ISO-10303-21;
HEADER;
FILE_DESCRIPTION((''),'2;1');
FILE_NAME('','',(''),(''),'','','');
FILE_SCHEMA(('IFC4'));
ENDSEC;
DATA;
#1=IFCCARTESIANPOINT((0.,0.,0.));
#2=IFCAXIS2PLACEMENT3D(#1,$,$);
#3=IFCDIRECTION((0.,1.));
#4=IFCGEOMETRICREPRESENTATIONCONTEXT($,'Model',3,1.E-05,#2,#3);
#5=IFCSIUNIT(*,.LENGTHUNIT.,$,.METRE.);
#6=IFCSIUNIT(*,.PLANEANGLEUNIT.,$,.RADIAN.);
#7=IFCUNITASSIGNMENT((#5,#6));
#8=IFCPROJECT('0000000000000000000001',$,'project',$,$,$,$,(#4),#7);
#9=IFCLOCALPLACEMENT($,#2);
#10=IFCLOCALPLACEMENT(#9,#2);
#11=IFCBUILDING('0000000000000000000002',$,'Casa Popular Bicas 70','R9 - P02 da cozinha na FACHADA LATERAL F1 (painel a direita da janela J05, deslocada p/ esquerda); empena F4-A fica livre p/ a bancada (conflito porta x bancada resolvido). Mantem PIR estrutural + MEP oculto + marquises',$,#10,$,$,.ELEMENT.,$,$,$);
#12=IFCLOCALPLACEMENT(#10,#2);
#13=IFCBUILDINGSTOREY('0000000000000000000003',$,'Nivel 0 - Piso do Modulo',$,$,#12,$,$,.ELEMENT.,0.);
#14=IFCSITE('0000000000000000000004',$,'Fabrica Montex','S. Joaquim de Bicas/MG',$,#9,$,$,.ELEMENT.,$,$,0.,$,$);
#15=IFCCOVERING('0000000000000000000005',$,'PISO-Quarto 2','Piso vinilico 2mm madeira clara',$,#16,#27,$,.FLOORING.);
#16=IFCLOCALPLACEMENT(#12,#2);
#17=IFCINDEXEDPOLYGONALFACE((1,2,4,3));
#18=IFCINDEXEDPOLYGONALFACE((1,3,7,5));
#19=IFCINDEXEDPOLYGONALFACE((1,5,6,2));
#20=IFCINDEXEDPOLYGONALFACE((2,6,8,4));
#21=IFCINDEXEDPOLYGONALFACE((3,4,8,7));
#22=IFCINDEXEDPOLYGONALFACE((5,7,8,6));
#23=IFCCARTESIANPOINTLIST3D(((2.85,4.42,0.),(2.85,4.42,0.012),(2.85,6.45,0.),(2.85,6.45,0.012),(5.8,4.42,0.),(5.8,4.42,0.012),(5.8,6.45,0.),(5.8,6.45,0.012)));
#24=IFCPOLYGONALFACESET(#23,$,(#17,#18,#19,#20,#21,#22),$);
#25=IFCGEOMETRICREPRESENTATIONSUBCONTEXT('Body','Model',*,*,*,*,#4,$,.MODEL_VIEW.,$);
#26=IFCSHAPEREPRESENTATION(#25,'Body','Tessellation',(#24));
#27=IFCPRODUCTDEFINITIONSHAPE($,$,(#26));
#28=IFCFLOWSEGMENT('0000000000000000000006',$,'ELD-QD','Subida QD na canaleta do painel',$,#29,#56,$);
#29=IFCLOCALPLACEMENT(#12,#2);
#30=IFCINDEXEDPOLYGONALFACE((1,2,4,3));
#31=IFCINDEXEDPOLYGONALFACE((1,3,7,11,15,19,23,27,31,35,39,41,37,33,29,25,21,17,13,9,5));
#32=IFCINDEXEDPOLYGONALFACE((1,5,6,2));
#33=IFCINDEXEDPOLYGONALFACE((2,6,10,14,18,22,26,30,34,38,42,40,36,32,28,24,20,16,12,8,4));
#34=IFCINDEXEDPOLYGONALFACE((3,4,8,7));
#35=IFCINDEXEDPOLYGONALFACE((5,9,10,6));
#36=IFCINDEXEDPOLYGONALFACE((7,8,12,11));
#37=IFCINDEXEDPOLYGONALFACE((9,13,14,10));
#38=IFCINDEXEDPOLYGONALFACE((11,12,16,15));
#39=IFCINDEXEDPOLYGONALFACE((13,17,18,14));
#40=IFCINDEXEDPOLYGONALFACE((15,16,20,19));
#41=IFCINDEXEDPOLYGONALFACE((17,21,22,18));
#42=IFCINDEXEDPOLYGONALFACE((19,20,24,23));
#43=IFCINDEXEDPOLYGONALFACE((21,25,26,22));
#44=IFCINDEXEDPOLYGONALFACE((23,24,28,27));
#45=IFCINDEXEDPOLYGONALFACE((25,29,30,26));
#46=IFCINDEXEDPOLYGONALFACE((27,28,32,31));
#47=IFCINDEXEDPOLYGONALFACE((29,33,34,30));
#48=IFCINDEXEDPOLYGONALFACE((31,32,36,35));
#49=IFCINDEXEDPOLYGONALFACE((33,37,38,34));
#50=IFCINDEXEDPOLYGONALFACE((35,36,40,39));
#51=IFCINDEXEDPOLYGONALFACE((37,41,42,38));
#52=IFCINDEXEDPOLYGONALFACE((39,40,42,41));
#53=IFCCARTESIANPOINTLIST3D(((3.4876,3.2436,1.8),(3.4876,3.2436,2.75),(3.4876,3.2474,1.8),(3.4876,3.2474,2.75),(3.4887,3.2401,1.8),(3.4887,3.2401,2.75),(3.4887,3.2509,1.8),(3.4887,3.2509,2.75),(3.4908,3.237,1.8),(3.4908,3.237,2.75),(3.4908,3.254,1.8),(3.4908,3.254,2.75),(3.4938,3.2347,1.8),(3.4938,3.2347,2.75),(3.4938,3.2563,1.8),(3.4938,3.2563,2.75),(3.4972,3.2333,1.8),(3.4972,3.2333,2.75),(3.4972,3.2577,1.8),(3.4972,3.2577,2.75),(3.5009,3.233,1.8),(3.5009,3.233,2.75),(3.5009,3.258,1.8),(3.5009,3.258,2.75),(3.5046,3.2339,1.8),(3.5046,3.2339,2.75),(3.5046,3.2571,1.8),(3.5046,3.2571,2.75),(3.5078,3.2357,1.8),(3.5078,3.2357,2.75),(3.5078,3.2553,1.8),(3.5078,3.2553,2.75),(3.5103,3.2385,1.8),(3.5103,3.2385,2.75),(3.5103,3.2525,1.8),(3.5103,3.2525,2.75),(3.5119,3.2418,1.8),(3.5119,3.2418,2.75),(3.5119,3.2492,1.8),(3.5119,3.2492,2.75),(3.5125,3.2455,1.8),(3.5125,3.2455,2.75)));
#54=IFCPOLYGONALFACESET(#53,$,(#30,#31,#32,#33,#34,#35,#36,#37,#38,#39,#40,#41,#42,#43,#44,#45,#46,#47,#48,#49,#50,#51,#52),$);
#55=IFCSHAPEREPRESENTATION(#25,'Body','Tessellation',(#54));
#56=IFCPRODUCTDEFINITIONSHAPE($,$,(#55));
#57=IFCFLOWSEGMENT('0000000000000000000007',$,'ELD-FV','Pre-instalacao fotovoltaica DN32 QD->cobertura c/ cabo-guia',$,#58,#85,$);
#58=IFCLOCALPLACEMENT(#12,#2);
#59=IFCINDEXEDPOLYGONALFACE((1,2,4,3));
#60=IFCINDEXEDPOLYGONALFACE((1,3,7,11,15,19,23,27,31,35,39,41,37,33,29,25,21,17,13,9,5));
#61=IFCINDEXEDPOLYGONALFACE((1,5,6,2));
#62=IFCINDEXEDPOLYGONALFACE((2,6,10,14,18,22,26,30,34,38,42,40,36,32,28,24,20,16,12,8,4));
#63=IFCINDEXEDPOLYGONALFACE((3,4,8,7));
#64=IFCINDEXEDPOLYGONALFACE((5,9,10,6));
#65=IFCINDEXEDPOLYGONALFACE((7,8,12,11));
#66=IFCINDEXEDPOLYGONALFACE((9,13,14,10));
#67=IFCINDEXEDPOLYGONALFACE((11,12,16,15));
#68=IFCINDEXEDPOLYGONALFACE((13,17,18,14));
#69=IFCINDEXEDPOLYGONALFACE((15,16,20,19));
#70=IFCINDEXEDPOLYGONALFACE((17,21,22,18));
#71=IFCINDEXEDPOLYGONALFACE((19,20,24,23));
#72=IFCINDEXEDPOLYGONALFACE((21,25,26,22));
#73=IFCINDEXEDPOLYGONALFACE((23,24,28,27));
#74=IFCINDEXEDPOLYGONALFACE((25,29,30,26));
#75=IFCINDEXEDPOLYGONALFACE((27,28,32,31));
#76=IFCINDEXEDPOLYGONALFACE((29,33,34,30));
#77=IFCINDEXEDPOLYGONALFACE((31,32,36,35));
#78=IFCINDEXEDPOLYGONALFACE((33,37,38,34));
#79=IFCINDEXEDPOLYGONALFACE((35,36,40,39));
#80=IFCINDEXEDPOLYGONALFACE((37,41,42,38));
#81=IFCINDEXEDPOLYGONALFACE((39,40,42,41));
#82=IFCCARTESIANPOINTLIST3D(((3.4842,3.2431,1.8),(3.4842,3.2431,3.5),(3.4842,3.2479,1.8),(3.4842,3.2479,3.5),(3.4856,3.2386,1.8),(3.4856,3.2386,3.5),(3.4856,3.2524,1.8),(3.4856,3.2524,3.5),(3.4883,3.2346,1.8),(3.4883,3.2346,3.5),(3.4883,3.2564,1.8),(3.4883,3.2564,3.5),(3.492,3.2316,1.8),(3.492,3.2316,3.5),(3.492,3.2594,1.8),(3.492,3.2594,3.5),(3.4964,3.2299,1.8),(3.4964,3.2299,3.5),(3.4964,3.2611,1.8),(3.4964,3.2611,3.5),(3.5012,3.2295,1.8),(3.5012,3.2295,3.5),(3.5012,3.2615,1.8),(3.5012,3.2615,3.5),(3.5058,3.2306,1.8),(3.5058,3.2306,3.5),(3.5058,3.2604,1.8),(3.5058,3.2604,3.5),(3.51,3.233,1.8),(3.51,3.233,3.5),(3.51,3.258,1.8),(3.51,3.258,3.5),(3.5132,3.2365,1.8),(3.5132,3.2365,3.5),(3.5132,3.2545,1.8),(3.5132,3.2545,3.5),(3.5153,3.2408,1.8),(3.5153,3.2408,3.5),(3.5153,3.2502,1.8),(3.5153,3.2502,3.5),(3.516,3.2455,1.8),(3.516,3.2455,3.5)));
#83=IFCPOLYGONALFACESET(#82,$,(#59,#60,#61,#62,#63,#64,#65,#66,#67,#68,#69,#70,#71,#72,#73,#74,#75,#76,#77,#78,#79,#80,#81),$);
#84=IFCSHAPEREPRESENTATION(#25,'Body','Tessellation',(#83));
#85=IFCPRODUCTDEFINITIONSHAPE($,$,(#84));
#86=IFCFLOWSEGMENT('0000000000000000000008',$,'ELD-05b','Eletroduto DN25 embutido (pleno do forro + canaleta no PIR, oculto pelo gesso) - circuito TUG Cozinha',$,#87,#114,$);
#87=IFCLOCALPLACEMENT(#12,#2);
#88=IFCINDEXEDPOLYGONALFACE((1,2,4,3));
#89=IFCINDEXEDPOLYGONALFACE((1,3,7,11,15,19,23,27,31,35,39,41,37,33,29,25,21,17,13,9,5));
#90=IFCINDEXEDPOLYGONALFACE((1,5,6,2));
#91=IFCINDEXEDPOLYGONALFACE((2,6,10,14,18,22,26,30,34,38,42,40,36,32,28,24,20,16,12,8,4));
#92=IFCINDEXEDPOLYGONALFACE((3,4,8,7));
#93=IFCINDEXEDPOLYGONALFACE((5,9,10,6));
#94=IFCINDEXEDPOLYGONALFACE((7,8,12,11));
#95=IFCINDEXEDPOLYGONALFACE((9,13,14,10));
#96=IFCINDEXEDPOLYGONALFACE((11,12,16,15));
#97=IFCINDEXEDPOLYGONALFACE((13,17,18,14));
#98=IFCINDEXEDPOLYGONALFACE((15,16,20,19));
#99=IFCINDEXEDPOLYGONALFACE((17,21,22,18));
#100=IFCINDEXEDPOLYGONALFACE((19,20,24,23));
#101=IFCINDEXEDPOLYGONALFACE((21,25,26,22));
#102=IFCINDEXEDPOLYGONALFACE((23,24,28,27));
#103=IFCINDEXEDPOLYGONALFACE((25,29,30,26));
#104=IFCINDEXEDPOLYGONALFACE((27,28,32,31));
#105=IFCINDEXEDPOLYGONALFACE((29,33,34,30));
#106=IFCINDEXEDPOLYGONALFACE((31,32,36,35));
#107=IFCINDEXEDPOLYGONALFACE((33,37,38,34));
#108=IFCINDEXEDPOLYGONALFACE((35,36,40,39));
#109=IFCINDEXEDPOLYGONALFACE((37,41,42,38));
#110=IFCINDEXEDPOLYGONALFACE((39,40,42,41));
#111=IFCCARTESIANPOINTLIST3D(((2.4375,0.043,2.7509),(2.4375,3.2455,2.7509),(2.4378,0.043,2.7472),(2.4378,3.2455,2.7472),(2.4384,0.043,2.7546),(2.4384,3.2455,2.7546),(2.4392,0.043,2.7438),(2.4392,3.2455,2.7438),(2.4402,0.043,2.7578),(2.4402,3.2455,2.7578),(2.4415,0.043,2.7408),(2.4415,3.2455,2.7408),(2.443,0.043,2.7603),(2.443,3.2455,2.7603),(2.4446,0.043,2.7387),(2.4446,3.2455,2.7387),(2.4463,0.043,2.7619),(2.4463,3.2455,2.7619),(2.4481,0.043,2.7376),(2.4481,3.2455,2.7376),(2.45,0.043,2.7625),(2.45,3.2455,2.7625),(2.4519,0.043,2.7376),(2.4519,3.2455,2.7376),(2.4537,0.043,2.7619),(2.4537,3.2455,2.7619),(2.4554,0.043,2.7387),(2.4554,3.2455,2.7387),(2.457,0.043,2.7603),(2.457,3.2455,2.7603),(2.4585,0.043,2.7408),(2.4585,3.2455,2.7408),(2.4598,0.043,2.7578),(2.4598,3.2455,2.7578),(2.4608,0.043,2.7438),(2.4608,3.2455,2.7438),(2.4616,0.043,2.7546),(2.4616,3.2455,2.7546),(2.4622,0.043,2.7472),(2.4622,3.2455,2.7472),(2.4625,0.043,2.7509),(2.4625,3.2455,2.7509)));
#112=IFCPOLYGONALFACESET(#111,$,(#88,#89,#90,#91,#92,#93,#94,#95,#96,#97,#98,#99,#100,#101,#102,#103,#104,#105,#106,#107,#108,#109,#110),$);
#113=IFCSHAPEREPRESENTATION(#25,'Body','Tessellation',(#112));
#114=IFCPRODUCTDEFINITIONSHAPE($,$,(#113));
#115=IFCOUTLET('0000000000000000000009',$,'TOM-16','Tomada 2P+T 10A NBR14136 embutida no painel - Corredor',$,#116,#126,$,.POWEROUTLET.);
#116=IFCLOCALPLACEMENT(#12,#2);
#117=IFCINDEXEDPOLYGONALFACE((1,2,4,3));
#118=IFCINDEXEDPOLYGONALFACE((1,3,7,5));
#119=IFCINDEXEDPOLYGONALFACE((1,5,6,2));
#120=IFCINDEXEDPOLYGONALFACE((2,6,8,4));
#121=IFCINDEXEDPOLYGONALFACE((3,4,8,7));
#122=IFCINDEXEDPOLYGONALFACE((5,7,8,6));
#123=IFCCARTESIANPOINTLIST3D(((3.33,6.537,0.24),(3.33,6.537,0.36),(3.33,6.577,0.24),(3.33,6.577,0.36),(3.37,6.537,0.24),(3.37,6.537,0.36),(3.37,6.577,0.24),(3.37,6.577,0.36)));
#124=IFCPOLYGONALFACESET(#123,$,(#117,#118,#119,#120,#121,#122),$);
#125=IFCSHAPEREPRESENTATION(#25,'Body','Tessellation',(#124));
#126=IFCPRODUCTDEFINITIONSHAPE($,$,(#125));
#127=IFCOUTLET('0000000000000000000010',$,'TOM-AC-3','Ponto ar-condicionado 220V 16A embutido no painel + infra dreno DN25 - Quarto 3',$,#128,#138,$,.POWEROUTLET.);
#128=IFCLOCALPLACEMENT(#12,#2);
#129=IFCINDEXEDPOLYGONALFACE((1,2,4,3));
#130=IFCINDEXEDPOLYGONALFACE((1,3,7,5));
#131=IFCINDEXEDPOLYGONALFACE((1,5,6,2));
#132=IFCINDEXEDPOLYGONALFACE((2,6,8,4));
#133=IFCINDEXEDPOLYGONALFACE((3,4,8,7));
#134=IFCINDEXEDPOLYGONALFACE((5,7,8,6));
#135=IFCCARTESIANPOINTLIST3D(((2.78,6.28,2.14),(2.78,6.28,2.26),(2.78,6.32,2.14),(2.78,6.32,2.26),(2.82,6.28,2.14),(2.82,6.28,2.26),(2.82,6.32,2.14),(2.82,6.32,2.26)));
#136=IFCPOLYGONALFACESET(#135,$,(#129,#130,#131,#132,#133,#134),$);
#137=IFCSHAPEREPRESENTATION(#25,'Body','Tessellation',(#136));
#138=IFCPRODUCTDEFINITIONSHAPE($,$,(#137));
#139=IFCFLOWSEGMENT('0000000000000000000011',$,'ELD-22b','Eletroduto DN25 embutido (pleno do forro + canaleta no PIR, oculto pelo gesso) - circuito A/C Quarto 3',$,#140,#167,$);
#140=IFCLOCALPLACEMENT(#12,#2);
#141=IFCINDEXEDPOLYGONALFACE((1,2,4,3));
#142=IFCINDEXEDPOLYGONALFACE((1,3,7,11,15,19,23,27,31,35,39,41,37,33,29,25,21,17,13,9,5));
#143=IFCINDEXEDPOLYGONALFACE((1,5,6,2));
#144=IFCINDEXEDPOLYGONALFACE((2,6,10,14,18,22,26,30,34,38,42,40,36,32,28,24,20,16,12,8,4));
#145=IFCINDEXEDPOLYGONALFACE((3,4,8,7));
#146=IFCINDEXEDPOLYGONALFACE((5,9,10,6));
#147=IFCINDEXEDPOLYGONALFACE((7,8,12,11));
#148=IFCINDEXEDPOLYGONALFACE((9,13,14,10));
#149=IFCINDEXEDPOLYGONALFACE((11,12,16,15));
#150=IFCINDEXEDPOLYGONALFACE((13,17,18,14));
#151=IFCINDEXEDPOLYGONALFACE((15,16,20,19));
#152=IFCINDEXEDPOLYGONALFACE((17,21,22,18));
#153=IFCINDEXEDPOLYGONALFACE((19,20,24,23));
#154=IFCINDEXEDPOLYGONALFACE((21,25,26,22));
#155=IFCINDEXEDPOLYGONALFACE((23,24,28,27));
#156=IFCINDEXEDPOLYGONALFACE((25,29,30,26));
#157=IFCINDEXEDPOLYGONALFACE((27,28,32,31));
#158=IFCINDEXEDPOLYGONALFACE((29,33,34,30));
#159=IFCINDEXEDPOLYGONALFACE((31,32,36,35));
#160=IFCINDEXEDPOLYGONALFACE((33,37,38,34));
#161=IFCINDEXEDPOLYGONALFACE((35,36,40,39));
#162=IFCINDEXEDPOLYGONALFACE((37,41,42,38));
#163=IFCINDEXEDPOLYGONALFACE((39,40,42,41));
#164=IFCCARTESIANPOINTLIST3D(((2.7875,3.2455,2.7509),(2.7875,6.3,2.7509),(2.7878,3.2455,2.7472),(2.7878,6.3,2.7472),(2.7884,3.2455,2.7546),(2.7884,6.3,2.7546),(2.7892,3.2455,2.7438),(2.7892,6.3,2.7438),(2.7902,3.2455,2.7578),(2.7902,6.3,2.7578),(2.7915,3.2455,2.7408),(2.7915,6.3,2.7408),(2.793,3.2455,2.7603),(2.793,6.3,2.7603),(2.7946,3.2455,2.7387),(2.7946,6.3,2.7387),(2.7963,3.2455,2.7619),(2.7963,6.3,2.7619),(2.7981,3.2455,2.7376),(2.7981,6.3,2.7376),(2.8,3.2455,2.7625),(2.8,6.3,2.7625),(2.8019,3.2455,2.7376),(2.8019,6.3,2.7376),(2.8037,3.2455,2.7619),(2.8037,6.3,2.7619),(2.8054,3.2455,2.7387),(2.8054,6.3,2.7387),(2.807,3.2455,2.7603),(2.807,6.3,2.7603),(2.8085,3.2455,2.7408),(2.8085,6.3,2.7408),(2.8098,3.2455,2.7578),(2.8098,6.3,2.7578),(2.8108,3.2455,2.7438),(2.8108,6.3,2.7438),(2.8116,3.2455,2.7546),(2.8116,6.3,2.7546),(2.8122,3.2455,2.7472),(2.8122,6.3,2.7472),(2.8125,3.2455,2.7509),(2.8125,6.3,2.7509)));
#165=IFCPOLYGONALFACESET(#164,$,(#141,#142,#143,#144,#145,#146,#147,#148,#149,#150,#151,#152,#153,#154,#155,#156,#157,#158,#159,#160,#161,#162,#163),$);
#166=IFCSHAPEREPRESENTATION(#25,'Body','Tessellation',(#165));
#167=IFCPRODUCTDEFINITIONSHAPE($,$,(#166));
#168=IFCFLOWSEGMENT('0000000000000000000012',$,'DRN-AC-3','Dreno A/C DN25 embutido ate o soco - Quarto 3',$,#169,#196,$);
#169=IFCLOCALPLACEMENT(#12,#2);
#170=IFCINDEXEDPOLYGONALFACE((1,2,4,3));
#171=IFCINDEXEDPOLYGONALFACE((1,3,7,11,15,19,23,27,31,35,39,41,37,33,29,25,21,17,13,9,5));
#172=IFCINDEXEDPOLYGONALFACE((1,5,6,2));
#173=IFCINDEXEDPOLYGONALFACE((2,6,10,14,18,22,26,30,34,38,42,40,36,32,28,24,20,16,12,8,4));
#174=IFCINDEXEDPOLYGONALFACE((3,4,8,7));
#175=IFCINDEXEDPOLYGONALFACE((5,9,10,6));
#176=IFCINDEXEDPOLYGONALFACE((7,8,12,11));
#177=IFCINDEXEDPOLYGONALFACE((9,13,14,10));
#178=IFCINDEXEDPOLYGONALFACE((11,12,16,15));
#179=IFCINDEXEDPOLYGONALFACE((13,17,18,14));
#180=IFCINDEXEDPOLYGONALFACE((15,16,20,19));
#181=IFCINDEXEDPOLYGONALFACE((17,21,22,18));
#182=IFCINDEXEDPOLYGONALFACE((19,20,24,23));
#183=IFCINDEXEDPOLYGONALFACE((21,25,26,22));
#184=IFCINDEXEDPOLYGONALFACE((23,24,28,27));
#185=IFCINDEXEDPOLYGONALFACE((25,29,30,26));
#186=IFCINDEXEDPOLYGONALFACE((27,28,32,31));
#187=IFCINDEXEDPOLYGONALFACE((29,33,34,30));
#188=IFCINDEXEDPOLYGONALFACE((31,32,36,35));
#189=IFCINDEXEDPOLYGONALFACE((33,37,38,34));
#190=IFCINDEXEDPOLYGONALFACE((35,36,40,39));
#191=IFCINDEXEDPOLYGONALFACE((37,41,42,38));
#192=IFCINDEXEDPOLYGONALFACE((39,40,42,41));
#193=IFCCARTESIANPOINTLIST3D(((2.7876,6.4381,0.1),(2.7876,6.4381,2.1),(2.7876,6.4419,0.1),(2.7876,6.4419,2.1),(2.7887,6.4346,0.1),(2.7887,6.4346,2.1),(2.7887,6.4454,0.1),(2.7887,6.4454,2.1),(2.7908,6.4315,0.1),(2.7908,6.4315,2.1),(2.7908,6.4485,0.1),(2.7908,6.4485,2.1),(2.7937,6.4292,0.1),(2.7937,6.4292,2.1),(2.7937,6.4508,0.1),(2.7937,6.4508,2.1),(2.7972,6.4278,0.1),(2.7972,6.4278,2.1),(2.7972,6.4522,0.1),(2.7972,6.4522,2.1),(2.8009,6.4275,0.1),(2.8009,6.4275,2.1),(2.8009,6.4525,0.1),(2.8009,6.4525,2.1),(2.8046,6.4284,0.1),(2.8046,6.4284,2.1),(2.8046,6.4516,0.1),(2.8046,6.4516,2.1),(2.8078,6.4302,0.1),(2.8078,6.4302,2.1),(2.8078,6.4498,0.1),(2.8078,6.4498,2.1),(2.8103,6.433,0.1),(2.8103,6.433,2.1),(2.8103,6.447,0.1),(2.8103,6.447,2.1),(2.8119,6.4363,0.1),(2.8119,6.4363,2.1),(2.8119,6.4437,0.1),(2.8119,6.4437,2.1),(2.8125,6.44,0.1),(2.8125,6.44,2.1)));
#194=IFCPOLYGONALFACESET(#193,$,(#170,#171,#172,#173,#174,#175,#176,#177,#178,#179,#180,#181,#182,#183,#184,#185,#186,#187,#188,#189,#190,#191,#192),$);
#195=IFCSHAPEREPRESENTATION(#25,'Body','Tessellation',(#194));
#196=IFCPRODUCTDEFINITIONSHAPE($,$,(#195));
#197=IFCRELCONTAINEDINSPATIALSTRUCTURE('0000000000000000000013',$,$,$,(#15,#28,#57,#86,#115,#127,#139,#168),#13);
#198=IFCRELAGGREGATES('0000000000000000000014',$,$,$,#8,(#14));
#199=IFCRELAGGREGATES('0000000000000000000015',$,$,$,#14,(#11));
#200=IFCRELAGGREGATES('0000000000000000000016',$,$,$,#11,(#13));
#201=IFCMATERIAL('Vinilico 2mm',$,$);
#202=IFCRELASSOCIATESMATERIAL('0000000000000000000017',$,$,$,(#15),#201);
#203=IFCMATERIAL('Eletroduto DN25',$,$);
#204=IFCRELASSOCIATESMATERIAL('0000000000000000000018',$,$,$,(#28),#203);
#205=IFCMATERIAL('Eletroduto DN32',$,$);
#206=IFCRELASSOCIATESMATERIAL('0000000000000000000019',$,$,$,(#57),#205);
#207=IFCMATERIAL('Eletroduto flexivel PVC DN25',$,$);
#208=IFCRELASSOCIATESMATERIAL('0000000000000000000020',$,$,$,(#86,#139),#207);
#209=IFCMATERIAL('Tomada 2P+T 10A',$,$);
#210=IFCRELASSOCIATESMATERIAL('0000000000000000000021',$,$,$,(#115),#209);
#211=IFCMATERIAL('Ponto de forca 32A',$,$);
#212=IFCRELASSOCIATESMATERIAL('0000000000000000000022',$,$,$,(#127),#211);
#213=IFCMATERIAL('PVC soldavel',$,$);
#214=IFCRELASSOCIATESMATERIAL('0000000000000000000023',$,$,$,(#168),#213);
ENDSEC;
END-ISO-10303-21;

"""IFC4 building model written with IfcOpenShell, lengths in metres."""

from ifc_helpers import new_model, si_unit, direction, frame, frame_2d, origin, origin_2d, place, context, subcontext, project, spatial, rectangle, circle, extrude, material, element, save


model = new_model("IFC4")

# Units and contexts
model_context = context("Model", 3, precision=1e-05, world=origin(), true_north=direction((0.0, 1.0)))
body_context = subcontext(model_context, "Body", "Model", "MODEL_VIEW")
ifc_project = project(units=[si_unit("LENGTHUNIT", "METRE"), si_unit("PLANEANGLEUNIT", "RADIAN")], contexts=[model_context])

# Site, building, storey
site_placement = place(None, origin())
site = spatial("IfcSite", under=ifc_project, at=site_placement, Name="Fabrica Montex", Description="S. Joaquim de Bicas/MG", CompositionType="ELEMENT", RefElevation=0.0)
building_placement = place(site_placement, origin())
building = spatial("IfcBuilding", under=site, at=building_placement, Name="Casa Popular Bicas 70", Description="R9 - P02 da cozinha na FACHADA LATERAL F1 (painel a direita da janela J05, deslocada p/ esquerda); empena F4-A fica livre p/ a bancada (conflito porta x bancada resolvido). Mantem PIR estrutural + MEP oculto + marquises", CompositionType="ELEMENT")
storey_placement = place(building_placement, origin())
storey = spatial("IfcBuildingStorey", under=building, at=storey_placement, Name="Nivel 0 - Piso do Modulo", CompositionType="ELEMENT", Elevation=0.0)

# Covering
ifc_material_1 = material(Name="Vinilico 2mm")
covering_1_placement = place(storey_placement, frame((2.85, 4.42, 0.0)))
element("IfcCovering", 1, at=covering_1_placement, inside=storey, material=ifc_material_1, Name="PISO-Quarto 2", Description="Piso vinilico 2mm madeira clara", PredefinedType="FLOORING", context=body_context, shape_type="SweptSolid", body=[
    extrude(rectangle(XDim=2.95, YDim=2.03, at=frame_2d((1.475, 1.015))), origin(), (0.0, 0.0, 1.0), 0.012),
])

# Flow segments
ifc_material_2 = material(Name="Eletroduto DN25")
flow_segment_1_placement = place(storey_placement, frame((3.5, 3.2455, 1.8), z_axis=(0.0, 0.0, 1.0), x_axis=(1.0, 0.0, 0.0)))
element("IfcFlowSegment", 2, at=flow_segment_1_placement, inside=storey, material=ifc_material_2, Name="ELD-QD", Description="Subida QD na canaleta do painel", context=body_context, shape_type="SweptSolid", body=[
    extrude(circle(Radius=0.0125, at=origin_2d()), origin(), (0.0, 0.0, 1.0), 0.95),
])
ifc_material_3 = material(Name="Eletroduto DN32")
flow_segment_2_placement = place(storey_placement, frame((3.5, 3.2455, 1.8), z_axis=(0.0, 0.0, 1.0), x_axis=(1.0, 0.0, 0.0)))
element("IfcFlowSegment", 3, at=flow_segment_2_placement, inside=storey, material=ifc_material_3, Name="ELD-FV", Description="Pre-instalacao fotovoltaica DN32 QD->cobertura c/ cabo-guia", context=body_context, shape_type="SweptSolid", body=[
    extrude(circle(Radius=0.016, at=origin_2d()), origin(), (0.0, 0.0, 1.0), 1.7),
])
ifc_material_4 = material(Name="Eletroduto flexivel PVC DN25")
flow_segment_3_placement = place(storey_placement, frame((2.45, 3.2455, 2.75), z_axis=(0.0, -1.0, 0.0), x_axis=(0.0, 0.0, 1.0)))
element("IfcFlowSegment", 4, at=flow_segment_3_placement, inside=storey, material=ifc_material_4, Name="ELD-05b", Description="Eletroduto DN25 embutido (pleno do forro + canaleta no PIR, oculto pelo gesso) - circuito TUG Cozinha", context=body_context, shape_type="SweptSolid", body=[
    extrude(circle(Radius=0.0125, at=origin_2d()), origin(), (0.0, 0.0, 1.0), 3.2025),
])

# Outlets
ifc_material_5 = material(Name="Tomada 2P+T 10A")
outlet_1_placement = place(storey_placement, frame((3.33, 6.537, 0.24)))
element("IfcOutlet", 5, at=outlet_1_placement, inside=storey, material=ifc_material_5, Name="TOM-16", Description="Tomada 2P+T 10A NBR14136 embutida no painel - Corredor", PredefinedType="POWEROUTLET", context=body_context, shape_type="SweptSolid", body=[
    extrude(rectangle(XDim=0.04, YDim=0.04, at=frame_2d((0.02, 0.02))), origin(), (0.0, 0.0, 1.0), 0.12),
])
ifc_material_6 = material(Name="Ponto de forca 32A")
outlet_2_placement = place(storey_placement, frame((2.78, 6.28, 2.14)))
element("IfcOutlet", 6, at=outlet_2_placement, inside=storey, material=ifc_material_6, Name="TOM-AC-3", Description="Ponto ar-condicionado 220V 16A embutido no painel + infra dreno DN25 - Quarto 3", PredefinedType="POWEROUTLET", context=body_context, shape_type="SweptSolid", body=[
    extrude(rectangle(XDim=0.04, YDim=0.04, at=frame_2d((0.02, 0.02))), origin(), (0.0, 0.0, 1.0), 0.12),
])

# Flow segments
flow_segment_4_placement = place(storey_placement, frame((2.8, 3.2455, 2.75), z_axis=(0.0, 1.0, 0.0), x_axis=(0.0, 0.0, 1.0)))
element("IfcFlowSegment", 7, at=flow_segment_4_placement, inside=storey, material=ifc_material_4, Name="ELD-22b", Description="Eletroduto DN25 embutido (pleno do forro + canaleta no PIR, oculto pelo gesso) - circuito A/C Quarto 3", context=body_context, shape_type="SweptSolid", body=[
    extrude(circle(Radius=0.0125, at=origin_2d()), origin(), (0.0, 0.0, 1.0), 3.0545),
])
ifc_material_7 = material(Name="PVC soldavel")
flow_segment_5_placement = place(storey_placement, frame((2.8, 6.44, 2.1), z_axis=(0.0, 0.0, -1.0), x_axis=(1.0, 0.0, 0.0)))
element("IfcFlowSegment", 8, at=flow_segment_5_placement, inside=storey, material=ifc_material_7, Name="DRN-AC-3", Description="Dreno A/C DN25 embutido ate o soco - Quarto 3", context=body_context, shape_type="SweptSolid", body=[
    extrude(circle(Radius=0.0125, at=origin_2d()), origin(), (0.0, 0.0, 1.0), 2.0),
])

save(model, "model.ifc")
